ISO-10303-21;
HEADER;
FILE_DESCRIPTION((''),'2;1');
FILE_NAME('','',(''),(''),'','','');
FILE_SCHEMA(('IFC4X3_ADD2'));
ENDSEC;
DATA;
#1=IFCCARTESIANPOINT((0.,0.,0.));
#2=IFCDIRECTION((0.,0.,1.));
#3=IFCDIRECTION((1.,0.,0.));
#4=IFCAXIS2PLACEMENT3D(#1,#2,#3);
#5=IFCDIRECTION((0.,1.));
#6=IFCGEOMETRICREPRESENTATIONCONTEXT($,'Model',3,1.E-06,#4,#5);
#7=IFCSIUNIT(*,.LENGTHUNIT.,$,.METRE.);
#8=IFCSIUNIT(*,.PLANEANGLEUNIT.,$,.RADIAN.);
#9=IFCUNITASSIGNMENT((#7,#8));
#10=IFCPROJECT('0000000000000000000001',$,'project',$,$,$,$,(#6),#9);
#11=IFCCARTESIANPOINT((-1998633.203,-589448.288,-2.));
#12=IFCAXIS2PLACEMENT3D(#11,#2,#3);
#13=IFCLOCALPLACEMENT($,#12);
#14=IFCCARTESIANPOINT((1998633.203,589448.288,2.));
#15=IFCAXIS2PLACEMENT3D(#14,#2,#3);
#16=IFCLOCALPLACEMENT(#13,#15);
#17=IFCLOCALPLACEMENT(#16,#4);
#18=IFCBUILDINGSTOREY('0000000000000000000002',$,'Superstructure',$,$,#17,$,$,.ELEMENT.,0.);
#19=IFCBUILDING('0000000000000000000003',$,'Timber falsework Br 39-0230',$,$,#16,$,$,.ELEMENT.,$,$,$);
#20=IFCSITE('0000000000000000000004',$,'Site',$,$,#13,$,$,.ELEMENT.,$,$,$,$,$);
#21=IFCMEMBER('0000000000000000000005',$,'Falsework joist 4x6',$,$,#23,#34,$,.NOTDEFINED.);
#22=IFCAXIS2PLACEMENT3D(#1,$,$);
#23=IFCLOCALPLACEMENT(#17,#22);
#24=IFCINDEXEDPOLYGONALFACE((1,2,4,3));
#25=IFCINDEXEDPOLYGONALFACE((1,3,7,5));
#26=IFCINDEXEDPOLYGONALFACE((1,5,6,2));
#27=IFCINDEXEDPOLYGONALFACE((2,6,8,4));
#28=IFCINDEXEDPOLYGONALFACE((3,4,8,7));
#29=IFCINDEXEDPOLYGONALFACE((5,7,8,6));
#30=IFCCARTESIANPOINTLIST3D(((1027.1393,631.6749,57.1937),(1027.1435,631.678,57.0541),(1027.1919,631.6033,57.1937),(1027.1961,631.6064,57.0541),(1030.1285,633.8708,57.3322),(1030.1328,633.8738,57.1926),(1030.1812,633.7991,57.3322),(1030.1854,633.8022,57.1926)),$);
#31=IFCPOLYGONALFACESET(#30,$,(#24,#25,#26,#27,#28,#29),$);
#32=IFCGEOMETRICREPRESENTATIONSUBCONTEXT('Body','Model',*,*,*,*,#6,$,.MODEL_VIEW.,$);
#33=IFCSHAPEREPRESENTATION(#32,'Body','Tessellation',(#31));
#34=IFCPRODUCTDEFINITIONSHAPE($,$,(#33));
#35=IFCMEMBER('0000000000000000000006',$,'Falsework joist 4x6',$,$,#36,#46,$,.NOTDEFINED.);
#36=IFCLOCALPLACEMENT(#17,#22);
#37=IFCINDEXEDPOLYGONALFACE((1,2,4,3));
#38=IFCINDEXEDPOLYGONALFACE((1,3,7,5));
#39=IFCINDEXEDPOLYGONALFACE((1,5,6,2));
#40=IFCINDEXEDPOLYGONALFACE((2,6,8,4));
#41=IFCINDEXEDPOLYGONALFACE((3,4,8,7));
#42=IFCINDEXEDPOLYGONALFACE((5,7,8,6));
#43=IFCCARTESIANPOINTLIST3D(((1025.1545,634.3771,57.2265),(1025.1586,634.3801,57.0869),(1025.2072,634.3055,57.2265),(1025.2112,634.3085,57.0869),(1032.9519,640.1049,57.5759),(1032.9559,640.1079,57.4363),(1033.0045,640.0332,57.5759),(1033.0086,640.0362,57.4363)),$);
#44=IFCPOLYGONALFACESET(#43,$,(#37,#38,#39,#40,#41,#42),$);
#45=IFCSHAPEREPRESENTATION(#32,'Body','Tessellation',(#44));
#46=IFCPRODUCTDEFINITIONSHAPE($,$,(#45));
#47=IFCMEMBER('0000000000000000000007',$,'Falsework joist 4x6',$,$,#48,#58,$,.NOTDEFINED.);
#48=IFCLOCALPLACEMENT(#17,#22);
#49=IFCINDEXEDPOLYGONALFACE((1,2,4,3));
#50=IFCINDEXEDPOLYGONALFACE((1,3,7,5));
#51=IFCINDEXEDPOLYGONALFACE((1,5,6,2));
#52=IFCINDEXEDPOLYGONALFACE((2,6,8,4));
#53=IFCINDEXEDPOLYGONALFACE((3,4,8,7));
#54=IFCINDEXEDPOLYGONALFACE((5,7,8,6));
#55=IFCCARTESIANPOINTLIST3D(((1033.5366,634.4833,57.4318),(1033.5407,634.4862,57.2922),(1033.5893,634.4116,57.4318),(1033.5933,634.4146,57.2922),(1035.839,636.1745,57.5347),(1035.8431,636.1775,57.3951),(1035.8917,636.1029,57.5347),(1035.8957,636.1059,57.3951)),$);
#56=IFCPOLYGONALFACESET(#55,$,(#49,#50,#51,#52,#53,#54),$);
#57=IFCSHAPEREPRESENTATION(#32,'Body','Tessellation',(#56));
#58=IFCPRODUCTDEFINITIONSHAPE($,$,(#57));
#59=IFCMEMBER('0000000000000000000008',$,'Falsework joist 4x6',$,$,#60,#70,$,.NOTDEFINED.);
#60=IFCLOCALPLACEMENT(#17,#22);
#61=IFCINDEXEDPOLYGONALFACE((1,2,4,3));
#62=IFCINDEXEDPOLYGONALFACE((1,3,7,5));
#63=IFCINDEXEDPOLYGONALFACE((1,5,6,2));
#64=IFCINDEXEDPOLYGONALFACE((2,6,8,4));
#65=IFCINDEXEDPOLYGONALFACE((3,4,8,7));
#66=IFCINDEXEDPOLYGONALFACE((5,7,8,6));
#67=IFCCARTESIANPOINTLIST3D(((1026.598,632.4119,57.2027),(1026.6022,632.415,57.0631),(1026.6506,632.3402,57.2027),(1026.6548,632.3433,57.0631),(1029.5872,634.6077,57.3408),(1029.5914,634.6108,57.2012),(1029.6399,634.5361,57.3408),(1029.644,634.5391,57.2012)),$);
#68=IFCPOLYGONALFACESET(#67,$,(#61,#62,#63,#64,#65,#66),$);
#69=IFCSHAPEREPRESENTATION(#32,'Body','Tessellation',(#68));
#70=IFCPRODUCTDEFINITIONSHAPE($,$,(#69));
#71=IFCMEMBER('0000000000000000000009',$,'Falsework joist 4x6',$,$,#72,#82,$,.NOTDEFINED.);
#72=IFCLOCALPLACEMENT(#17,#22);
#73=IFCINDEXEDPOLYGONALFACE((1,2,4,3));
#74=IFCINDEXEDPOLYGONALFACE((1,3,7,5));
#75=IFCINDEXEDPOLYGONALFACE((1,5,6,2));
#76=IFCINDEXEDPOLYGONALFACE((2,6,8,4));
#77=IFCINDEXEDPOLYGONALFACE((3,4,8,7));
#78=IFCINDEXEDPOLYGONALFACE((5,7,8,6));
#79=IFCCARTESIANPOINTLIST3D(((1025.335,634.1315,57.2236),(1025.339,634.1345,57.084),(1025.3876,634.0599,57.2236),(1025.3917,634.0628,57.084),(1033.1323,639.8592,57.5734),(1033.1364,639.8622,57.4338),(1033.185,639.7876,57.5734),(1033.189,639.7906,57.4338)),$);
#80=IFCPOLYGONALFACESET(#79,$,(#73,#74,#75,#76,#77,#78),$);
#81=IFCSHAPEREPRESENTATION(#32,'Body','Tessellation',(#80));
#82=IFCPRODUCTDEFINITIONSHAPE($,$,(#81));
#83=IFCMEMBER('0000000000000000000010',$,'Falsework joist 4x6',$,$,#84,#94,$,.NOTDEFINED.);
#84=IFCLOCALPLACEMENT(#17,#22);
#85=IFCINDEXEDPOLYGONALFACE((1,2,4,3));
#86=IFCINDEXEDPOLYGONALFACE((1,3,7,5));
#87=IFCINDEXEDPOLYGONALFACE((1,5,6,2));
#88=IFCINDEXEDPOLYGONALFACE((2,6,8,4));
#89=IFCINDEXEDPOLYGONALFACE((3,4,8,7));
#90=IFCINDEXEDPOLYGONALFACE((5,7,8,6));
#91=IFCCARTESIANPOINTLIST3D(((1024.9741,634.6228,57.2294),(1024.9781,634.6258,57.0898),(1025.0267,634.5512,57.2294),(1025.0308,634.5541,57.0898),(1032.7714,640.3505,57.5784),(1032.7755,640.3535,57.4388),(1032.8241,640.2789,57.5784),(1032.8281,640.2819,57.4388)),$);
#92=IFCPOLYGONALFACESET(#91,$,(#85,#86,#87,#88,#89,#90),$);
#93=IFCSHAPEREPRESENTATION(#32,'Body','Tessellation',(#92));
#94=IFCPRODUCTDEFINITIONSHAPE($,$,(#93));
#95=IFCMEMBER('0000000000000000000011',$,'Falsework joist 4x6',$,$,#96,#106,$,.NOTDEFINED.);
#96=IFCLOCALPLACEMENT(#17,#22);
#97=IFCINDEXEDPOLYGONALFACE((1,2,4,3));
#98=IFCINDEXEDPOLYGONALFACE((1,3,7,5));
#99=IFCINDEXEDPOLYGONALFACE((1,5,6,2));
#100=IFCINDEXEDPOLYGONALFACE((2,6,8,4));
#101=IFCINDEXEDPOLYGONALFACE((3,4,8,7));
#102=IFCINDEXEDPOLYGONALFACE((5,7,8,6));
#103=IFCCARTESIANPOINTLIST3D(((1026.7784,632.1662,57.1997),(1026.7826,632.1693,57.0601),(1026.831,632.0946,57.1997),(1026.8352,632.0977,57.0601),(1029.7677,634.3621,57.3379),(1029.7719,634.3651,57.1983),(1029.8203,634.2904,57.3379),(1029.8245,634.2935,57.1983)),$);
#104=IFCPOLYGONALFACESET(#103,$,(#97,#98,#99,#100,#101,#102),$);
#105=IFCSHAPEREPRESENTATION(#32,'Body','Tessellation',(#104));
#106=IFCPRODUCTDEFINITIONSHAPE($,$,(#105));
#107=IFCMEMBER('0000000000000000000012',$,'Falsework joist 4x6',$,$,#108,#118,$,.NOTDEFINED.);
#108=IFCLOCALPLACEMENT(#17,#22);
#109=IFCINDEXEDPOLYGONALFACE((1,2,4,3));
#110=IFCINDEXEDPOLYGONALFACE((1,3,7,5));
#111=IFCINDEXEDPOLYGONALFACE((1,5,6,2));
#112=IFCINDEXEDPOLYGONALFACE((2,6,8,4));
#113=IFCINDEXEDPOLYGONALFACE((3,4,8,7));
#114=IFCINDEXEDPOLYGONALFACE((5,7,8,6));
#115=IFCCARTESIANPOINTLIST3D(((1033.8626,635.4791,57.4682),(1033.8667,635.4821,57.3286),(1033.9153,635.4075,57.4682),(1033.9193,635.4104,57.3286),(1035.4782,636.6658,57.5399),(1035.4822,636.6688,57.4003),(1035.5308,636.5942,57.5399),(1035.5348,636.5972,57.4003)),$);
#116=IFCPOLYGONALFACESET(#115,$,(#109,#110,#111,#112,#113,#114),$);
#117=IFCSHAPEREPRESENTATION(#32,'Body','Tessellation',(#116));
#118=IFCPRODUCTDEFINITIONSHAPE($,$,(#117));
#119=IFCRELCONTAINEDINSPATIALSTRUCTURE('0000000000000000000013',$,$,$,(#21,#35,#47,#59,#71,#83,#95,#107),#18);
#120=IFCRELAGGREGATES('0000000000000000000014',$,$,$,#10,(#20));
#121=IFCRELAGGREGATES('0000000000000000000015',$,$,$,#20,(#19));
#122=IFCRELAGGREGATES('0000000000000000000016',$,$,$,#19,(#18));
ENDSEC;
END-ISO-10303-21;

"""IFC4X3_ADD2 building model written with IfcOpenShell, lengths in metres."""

from ifc_helpers import new_model, si_unit, direction, frame, frame_2d, origin, origin_with_axes, place, context, subcontext, project, spatial, rectangle, extrude, element, save


model = new_model("IFC4X3_ADD2")

# Units and contexts
model_context = context("Model", 3, precision=1e-06, world=origin_with_axes(), true_north=direction((0.0, 1.0)))
body_context = subcontext(model_context, "Body", "Model", "MODEL_VIEW")
ifc_project = project(units=[si_unit("LENGTHUNIT", "METRE"), si_unit("PLANEANGLEUNIT", "RADIAN")], contexts=[model_context])

# Site, building, storey
site_placement = place(None, frame((-1998633.203, -589448.288, -2.0), z_axis=(0.0, 0.0, 1.0), x_axis=(1.0, 0.0, 0.0)))
site = spatial("IfcSite", under=ifc_project, at=site_placement, Name="Site", CompositionType="ELEMENT")
building_placement = place(site_placement, frame((1998633.203, 589448.288, 2.0), z_axis=(0.0, 0.0, 1.0), x_axis=(1.0, 0.0, 0.0)))
building = spatial("IfcBuilding", under=site, at=building_placement, Name="Timber falsework Br 39-0230", CompositionType="ELEMENT")
storey_placement = place(building_placement, origin_with_axes())
storey = spatial("IfcBuildingStorey", under=building, at=storey_placement, Name="Superstructure", CompositionType="ELEMENT", Elevation=0.0)

# Members
member_1_placement = place(storey_placement, frame((1027.1698, 631.6422, 57.0541), z_axis=(0.805366, 0.5916, 0.037333), x_axis=(-0.592013, 0.805928, 0.0)))
element("IfcMember", 1, at=member_1_placement, inside=storey, Name="Falsework joist 4x6", PredefinedType="NOTDEFINED", context=body_context, shape_type="SweptSolid", body=[
    extrude(rectangle(XDim=0.0889, YDim=0.1397, at=frame_2d((0.0, 0.0698))), origin(), (0.0, 0.0, 1.0), 3.7117),
])
member_2_placement = place(storey_placement, frame((1025.1849, 634.3443, 57.0869), z_axis=(0.805403, 0.591628, 0.03609), x_axis=(-0.592013, 0.805928, 0.0)))
element("IfcMember", 2, at=member_2_placement, inside=storey, Name="Falsework joist 4x6", PredefinedType="NOTDEFINED", context=body_context, shape_type="SweptSolid", body=[
    extrude(rectangle(XDim=0.0889, YDim=0.1397, at=frame_2d((0.0, 0.0698))), origin(), (0.0, 0.0, 1.0), 9.6813),
])
member_3_placement = place(storey_placement, frame((1033.567, 634.4504, 57.2922), z_axis=(0.805406, 0.59163, 0.035979), x_axis=(-0.592013, 0.805928, 0.0)))
element("IfcMember", 3, at=member_3_placement, inside=storey, Name="Falsework joist 4x6", PredefinedType="NOTDEFINED", context=body_context, shape_type="SweptSolid", body=[
    extrude(rectangle(XDim=0.0889, YDim=0.1397, at=frame_2d((0.0, 0.0698))), origin(), (0.0, 0.0, 1.0), 2.8587),
])
member_4_placement = place(storey_placement, frame((1026.6285, 632.3791, 57.0631), z_axis=(0.805371, 0.591604, 0.037192), x_axis=(-0.592013, 0.805928, 0.0)))
element("IfcMember", 4, at=member_4_placement, inside=storey, Name="Falsework joist 4x6", PredefinedType="NOTDEFINED", context=body_context, shape_type="SweptSolid", body=[
    extrude(rectangle(XDim=0.0889, YDim=0.1397, at=frame_2d((0.0, 0.0698))), origin(), (0.0, 0.0, 1.0), 3.7117),
])
member_5_placement = place(storey_placement, frame((1025.3653, 634.0987, 57.084), z_axis=(0.805402, 0.591627, 0.036134), x_axis=(-0.592013, 0.805928, 0.0)))
element("IfcMember", 5, at=member_5_placement, inside=storey, Name="Falsework joist 4x6", PredefinedType="NOTDEFINED", context=body_context, shape_type="SweptSolid", body=[
    extrude(rectangle(XDim=0.0889, YDim=0.1397, at=frame_2d((0.0, 0.0698))), origin(), (0.0, 0.0, 1.0), 9.6813),
])
member_6_placement = place(storey_placement, frame((1025.0045, 634.59, 57.0898), z_axis=(0.805405, 0.591628, 0.036046), x_axis=(-0.592013, 0.805928, 0.0)))
element("IfcMember", 6, at=member_6_placement, inside=storey, Name="Falsework joist 4x6", PredefinedType="NOTDEFINED", context=body_context, shape_type="SweptSolid", body=[
    extrude(rectangle(XDim=0.0889, YDim=0.1397, at=frame_2d((0.0, 0.0698))), origin(), (0.0, 0.0, 1.0), 9.6813),
])
member_7_placement = place(storey_placement, frame((1026.8089, 632.1335, 57.0601), z_axis=(0.805369, 0.591603, 0.037239), x_axis=(-0.592013, 0.805928, 0.0)))
element("IfcMember", 7, at=member_7_placement, inside=storey, Name="Falsework joist 4x6", PredefinedType="NOTDEFINED", context=body_context, shape_type="SweptSolid", body=[
    extrude(rectangle(XDim=0.0889, YDim=0.1397, at=frame_2d((0.0, 0.0698))), origin(), (0.0, 0.0, 1.0), 3.7117),
])
member_8_placement = place(storey_placement, frame((1033.893, 635.4463, 57.3286), z_axis=(0.805413, 0.591634, 0.035762), x_axis=(-0.592013, 0.805928, 0.0)))
element("IfcMember", 8, at=member_8_placement, inside=storey, Name="Falsework joist 4x6", PredefinedType="NOTDEFINED", context=body_context, shape_type="SweptSolid", body=[
    extrude(rectangle(XDim=0.0889, YDim=0.1397, at=frame_2d((0.0, 0.0698))), origin(), (0.0, 0.0, 1.0), 2.0058),
])

save(model, "model.ifc")
